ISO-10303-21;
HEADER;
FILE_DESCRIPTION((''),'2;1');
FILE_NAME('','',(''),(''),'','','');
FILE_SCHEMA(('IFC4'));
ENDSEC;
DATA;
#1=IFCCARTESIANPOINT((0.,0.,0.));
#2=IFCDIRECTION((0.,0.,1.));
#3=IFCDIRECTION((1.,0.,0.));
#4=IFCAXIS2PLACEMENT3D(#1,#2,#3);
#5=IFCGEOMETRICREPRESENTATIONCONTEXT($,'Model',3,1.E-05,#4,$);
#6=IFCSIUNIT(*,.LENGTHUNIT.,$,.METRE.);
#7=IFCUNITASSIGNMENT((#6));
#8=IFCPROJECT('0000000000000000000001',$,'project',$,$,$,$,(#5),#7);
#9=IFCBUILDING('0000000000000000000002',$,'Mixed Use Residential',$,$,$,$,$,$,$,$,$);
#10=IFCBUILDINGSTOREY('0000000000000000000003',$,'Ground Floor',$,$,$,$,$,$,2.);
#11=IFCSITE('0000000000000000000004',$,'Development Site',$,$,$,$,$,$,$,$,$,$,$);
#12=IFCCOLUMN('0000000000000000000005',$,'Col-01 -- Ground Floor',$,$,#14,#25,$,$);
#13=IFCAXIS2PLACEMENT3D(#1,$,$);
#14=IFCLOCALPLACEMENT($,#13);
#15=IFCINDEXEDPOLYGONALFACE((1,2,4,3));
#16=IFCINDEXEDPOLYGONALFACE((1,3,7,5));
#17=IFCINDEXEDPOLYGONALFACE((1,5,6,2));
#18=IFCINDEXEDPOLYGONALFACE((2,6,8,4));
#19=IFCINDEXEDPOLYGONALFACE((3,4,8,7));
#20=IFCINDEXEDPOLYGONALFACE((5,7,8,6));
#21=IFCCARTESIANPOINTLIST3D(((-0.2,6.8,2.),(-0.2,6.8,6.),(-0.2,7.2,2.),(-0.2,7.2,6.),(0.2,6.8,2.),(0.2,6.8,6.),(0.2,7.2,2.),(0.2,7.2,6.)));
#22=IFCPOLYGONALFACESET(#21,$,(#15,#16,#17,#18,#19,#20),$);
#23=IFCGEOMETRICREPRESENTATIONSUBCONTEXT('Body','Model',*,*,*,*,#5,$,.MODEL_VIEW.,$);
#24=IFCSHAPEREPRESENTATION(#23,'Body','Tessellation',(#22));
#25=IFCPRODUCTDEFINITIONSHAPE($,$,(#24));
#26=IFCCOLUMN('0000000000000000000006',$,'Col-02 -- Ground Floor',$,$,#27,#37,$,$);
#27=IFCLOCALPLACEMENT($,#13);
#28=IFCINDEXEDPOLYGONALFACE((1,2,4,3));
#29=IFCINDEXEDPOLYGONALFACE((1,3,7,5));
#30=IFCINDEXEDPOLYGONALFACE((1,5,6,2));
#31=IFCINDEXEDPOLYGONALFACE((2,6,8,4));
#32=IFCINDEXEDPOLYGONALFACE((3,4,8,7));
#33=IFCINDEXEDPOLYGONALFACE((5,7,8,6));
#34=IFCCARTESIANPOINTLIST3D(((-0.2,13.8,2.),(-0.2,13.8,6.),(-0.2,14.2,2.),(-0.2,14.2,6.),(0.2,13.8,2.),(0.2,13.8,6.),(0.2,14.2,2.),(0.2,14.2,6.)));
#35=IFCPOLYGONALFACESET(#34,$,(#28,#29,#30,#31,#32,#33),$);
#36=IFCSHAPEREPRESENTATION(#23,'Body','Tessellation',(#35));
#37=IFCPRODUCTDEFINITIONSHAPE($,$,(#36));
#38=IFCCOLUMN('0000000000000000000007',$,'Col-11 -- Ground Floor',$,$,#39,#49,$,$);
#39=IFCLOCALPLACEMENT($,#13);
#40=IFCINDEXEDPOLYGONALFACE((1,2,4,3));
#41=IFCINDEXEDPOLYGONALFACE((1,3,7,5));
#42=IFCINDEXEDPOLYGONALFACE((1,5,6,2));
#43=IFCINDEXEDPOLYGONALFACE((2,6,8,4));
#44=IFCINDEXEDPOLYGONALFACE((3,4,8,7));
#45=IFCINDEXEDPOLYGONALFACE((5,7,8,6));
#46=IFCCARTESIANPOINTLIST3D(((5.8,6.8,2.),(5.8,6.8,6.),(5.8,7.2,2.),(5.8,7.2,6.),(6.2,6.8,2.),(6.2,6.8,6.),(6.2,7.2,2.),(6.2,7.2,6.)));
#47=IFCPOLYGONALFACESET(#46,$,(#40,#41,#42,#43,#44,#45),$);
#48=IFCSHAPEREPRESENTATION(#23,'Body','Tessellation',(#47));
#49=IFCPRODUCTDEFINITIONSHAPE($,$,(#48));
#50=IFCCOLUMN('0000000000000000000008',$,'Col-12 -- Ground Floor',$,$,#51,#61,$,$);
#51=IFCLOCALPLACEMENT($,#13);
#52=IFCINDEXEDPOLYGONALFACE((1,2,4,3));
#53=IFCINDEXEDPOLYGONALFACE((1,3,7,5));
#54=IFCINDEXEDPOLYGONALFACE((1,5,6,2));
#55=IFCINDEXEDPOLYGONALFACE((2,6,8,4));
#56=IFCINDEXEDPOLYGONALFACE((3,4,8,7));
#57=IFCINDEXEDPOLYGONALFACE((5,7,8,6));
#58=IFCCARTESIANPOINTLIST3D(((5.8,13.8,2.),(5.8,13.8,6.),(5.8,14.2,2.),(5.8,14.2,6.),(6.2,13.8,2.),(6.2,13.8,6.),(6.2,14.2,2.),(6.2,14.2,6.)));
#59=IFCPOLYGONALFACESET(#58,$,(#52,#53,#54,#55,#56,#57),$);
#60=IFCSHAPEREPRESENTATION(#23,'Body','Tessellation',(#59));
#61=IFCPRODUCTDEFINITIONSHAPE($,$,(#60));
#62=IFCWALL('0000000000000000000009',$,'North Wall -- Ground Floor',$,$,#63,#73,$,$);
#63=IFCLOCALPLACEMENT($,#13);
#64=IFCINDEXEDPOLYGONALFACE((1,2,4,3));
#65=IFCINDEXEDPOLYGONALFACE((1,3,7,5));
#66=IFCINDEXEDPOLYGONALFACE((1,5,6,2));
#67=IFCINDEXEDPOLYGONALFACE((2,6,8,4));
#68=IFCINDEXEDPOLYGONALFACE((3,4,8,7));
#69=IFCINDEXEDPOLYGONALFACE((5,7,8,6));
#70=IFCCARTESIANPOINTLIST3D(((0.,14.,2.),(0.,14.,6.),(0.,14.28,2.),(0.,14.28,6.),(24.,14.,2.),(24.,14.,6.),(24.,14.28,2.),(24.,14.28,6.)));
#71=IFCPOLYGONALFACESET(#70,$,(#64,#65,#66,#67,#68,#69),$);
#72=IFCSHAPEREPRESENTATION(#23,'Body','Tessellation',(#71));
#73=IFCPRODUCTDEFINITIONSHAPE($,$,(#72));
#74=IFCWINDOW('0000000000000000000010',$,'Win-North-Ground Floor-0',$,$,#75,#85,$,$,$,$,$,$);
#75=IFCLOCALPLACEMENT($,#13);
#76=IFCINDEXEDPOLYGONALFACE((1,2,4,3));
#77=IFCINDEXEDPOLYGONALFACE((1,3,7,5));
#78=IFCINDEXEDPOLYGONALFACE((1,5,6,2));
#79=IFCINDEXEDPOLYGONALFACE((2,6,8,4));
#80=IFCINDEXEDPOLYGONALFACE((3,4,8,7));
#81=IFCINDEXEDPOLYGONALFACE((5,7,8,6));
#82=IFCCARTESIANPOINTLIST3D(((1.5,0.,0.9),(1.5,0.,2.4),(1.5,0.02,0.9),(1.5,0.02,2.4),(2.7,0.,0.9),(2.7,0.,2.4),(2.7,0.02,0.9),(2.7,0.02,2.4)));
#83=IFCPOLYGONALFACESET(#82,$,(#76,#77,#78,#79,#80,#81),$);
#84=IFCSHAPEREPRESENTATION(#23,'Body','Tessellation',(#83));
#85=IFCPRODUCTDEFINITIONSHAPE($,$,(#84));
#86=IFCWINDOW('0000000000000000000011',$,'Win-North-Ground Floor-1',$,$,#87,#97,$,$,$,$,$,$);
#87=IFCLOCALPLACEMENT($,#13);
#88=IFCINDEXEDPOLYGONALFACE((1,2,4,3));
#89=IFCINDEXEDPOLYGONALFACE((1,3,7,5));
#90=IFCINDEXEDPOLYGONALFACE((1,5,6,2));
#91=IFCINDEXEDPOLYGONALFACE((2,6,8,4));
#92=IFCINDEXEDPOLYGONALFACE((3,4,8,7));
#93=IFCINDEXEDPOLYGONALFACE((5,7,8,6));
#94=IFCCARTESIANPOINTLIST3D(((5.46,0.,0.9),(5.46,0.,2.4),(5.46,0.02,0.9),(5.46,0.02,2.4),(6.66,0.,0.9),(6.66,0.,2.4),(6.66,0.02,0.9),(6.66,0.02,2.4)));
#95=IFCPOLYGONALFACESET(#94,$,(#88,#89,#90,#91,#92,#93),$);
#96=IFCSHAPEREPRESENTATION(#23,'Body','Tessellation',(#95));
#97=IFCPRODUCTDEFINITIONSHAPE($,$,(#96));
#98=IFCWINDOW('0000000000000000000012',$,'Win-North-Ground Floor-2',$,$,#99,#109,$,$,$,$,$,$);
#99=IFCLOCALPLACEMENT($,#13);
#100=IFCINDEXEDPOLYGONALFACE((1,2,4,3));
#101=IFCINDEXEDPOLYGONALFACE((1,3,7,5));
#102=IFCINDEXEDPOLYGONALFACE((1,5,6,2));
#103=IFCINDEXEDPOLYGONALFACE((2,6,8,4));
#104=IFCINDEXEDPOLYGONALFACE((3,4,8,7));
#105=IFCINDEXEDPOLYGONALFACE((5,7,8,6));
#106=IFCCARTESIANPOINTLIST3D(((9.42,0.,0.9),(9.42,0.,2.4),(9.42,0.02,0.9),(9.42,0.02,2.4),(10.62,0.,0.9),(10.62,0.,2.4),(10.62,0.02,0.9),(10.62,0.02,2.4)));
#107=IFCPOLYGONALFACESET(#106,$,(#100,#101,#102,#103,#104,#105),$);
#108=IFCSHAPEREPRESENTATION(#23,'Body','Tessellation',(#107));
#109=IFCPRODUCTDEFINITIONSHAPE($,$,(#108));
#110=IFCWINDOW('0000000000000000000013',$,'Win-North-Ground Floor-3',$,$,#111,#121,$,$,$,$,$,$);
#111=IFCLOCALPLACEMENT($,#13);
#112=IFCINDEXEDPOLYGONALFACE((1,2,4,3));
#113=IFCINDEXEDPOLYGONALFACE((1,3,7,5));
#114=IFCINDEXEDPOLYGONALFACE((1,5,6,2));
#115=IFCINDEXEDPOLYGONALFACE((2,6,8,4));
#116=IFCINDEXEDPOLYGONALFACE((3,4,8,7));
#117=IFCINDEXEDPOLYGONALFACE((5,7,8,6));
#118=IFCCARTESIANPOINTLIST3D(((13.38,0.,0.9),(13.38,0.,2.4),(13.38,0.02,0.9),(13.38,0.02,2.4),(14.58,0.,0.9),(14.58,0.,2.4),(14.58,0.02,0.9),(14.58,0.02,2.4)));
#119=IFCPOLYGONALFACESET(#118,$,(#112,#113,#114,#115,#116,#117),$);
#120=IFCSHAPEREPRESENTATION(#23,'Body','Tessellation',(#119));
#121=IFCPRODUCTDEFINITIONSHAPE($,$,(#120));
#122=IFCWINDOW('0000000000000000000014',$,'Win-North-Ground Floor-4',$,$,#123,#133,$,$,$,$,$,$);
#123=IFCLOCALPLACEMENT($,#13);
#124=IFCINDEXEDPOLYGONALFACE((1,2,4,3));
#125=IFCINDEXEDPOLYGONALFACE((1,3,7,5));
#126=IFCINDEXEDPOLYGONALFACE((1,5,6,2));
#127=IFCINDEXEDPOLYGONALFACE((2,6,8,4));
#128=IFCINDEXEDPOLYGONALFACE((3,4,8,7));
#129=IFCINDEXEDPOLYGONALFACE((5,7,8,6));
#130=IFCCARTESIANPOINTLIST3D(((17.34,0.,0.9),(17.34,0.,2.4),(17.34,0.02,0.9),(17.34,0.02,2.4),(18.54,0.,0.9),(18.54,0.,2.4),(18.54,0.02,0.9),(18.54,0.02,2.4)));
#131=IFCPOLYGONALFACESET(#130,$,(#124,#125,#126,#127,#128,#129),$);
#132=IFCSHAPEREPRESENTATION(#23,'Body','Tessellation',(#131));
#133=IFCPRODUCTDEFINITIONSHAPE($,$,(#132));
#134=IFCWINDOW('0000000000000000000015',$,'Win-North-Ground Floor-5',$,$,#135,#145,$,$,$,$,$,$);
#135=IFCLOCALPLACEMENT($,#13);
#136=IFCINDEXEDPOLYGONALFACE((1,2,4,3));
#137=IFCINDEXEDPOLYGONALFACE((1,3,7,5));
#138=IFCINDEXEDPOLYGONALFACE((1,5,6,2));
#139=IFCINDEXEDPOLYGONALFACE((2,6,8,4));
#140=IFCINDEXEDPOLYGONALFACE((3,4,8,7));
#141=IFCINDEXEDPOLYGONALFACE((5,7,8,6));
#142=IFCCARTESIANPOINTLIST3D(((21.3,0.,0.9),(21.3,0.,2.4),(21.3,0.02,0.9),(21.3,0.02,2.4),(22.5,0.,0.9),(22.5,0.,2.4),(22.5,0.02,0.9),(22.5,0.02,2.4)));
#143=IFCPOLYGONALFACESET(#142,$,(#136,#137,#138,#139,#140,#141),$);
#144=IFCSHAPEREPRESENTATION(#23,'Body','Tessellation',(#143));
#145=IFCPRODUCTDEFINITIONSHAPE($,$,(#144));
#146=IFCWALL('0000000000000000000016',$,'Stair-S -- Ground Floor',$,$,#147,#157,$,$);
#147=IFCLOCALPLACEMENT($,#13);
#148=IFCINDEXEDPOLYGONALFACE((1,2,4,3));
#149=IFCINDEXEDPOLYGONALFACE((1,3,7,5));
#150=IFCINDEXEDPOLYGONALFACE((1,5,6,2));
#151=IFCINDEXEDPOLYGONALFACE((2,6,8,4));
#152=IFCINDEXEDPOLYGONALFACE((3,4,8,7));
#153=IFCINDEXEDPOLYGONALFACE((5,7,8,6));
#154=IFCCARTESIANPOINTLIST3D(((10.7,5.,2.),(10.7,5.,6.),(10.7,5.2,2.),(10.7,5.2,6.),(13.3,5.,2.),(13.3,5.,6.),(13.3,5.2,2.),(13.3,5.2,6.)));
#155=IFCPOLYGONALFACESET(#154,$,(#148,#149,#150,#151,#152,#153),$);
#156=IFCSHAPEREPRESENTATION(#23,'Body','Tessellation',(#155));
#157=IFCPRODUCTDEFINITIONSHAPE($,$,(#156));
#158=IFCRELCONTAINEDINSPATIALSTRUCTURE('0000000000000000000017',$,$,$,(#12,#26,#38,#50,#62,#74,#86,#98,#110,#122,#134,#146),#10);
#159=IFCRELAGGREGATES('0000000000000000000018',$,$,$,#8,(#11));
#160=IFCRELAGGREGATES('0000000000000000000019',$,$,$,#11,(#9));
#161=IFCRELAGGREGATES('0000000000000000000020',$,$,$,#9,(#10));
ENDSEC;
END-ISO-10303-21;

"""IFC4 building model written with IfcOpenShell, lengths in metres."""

from ifc_helpers import new_model, si_unit, frame, origin_with_axes, place, context, subcontext, project, spatial, indexed_curve, rectangle, outline, extrude, element, fill, save


model = new_model("IFC4")

# Units and contexts
model_context = context("Model", 3, precision=1e-05, world=origin_with_axes())
body_context = subcontext(model_context, "Body", "Model", "MODEL_VIEW")
ifc_project = project(units=[si_unit("LENGTHUNIT", "METRE")], contexts=[model_context])

# Site, building, storey
site = spatial("IfcSite", under=ifc_project, Name="Development Site")
building = spatial("IfcBuilding", under=site, Name="Mixed Use Residential")
storey = spatial("IfcBuildingStorey", under=building, Name="Ground Floor", Elevation=2.0)

# Columns
for number, where, z_axis, x_axis, name in (
    (1, (0.0, 7.0, 2.0), (0.0, 0.0, 1.0), (1.0, 0.0, 0.0), "Col-01 -- Ground Floor"),
    (2, (0.0, 14.0, 2.0), (0.0, 0.0, 1.0), (1.0, 0.0, 0.0), "Col-02 -- Ground Floor"),
    (3, (6.0, 7.0, 2.0), (0.0, 0.0, 1.0), (1.0, 0.0, 0.0), "Col-11 -- Ground Floor"),
    (4, (6.0, 14.0, 2.0), (0.0, 0.0, 1.0), (1.0, 0.0, 0.0), "Col-12 -- Ground Floor"),
):
    element("IfcColumn", number, at=place(None, frame(where, z_axis=z_axis, x_axis=x_axis)), inside=storey, Name=name, context=body_context, shape_type="SweptSolid", body=[
        extrude(rectangle(XDim=0.4, YDim=0.4), origin_with_axes(), (0.0, 0.0, 1.0), 4.0),
    ])

# Wall, openings, windows
wall_1_placement = place(None, frame((0.0, 14.0, 2.0), z_axis=(0.0, 0.0, 1.0), x_axis=(1.0, 0.0, 0.0)))
wall_1 = element("IfcWall", 5, at=wall_1_placement, inside=storey, Name="North Wall -- Ground Floor", context=body_context, shape_type="SweptSolid", body=[
    extrude(outline(indexed_curve([(0.0, 0.0), (0.0, 0.28), (24.0, 0.28), (24.0, 0.0), (0.0, 0.0)], self_intersect=False)), origin_with_axes(), (0.0, 0.0, 1.0), 4.0),
])
opening_1_placement = place(wall_1_placement, frame((1.5, -14.0, -1.1), z_axis=(0.0, 0.0, 1.0), x_axis=(1.0, 0.0, 0.0)))
opening_1 = element("IfcOpeningElement", 6, at=opening_1_placement, cuts=wall_1, context=body_context, shape_type="SweptSolid", body=[
    extrude(outline(indexed_curve([(0.0, 0.0), (0.0, 0.28), (1.2, 0.28), (1.2, 0.0), (0.0, 0.0)], self_intersect=False)), origin_with_axes(), (0.0, 0.0, 1.0), 1.5),
])
opening_2_placement = place(wall_1_placement, frame((5.46, -14.0, -1.1), z_axis=(0.0, 0.0, 1.0), x_axis=(1.0, 0.0, 0.0)))
opening_2 = element("IfcOpeningElement", 7, at=opening_2_placement, cuts=wall_1, context=body_context, shape_type="SweptSolid", body=[
    extrude(outline(indexed_curve([(0.0, 0.0), (0.0, 0.28), (1.2, 0.28), (1.2, 0.0), (0.0, 0.0)], self_intersect=False)), origin_with_axes(), (0.0, 0.0, 1.0), 1.5),
])
opening_3_placement = place(wall_1_placement, frame((9.42, -14.0, -1.1), z_axis=(0.0, 0.0, 1.0), x_axis=(1.0, 0.0, 0.0)))
opening_3 = element("IfcOpeningElement", 8, at=opening_3_placement, cuts=wall_1, context=body_context, shape_type="SweptSolid", body=[
    extrude(outline(indexed_curve([(0.0, 0.0), (0.0, 0.28), (1.2, 0.28), (1.2, 0.0), (0.0, 0.0)], self_intersect=False)), origin_with_axes(), (0.0, 0.0, 1.0), 1.5),
])
opening_4_placement = place(wall_1_placement, frame((13.38, -14.0, -1.1), z_axis=(0.0, 0.0, 1.0), x_axis=(1.0, 0.0, 0.0)))
opening_4 = element("IfcOpeningElement", 9, at=opening_4_placement, cuts=wall_1, context=body_context, shape_type="SweptSolid", body=[
    extrude(outline(indexed_curve([(0.0, 0.0), (0.0, 0.28), (1.2, 0.28), (1.2, 0.0), (0.0, 0.0)], self_intersect=False)), origin_with_axes(), (0.0, 0.0, 1.0), 1.5),
])
opening_5_placement = place(wall_1_placement, frame((17.34, -14.0, -1.1), z_axis=(0.0, 0.0, 1.0), x_axis=(1.0, 0.0, 0.0)))
opening_5 = element("IfcOpeningElement", 10, at=opening_5_placement, cuts=wall_1, context=body_context, shape_type="SweptSolid", body=[
    extrude(outline(indexed_curve([(0.0, 0.0), (0.0, 0.28), (1.2, 0.28), (1.2, 0.0), (0.0, 0.0)], self_intersect=False)), origin_with_axes(), (0.0, 0.0, 1.0), 1.5),
])
opening_6_placement = place(wall_1_placement, frame((21.3, -14.0, -1.1), z_axis=(0.0, 0.0, 1.0), x_axis=(1.0, 0.0, 0.0)))
opening_6 = element("IfcOpeningElement", 11, at=opening_6_placement, cuts=wall_1, context=body_context, shape_type="SweptSolid", body=[
    extrude(outline(indexed_curve([(0.0, 0.0), (0.0, 0.28), (1.2, 0.28), (1.2, 0.0), (0.0, 0.0)], self_intersect=False)), origin_with_axes(), (0.0, 0.0, 1.0), 1.5),
])
window_1_placement = place(None, frame((1.5, 0.0, 0.9), z_axis=(0.0, 0.0, 1.0), x_axis=(1.0, 0.0, 0.0)))
window_1 = element("IfcWindow", 12, at=window_1_placement, inside=storey, Name="Win-North-Ground Floor-0", context=body_context, shape_type="SweptSolid", body=[
    extrude(outline(indexed_curve([(0.0, 0.0), (0.0, 0.02), (1.2, 0.02), (1.2, 0.0), (0.0, 0.0)], self_intersect=False)), origin_with_axes(), (0.0, 0.0, 1.0), 1.5),
])
fill(opening_1, window_1)
window_2_placement = place(None, frame((5.46, 0.0, 0.9), z_axis=(0.0, 0.0, 1.0), x_axis=(1.0, 0.0, 0.0)))
window_2 = element("IfcWindow", 13, at=window_2_placement, inside=storey, Name="Win-North-Ground Floor-1", context=body_context, shape_type="SweptSolid", body=[
    extrude(outline(indexed_curve([(0.0, 0.0), (0.0, 0.02), (1.2, 0.02), (1.2, 0.0), (0.0, 0.0)], self_intersect=False)), origin_with_axes(), (0.0, 0.0, 1.0), 1.5),
])
fill(opening_2, window_2)
window_3_placement = place(None, frame((9.42, 0.0, 0.9), z_axis=(0.0, 0.0, 1.0), x_axis=(1.0, 0.0, 0.0)))
window_3 = element("IfcWindow", 14, at=window_3_placement, inside=storey, Name="Win-North-Ground Floor-2", context=body_context, shape_type="SweptSolid", body=[
    extrude(outline(indexed_curve([(0.0, 0.0), (0.0, 0.02), (1.2, 0.02), (1.2, 0.0), (0.0, 0.0)], self_intersect=False)), origin_with_axes(), (0.0, 0.0, 1.0), 1.5),
])
fill(opening_3, window_3)
window_4_placement = place(None, frame((13.38, 0.0, 0.9), z_axis=(0.0, 0.0, 1.0), x_axis=(1.0, 0.0, 0.0)))
window_4 = element("IfcWindow", 15, at=window_4_placement, inside=storey, Name="Win-North-Ground Floor-3", context=body_context, shape_type="SweptSolid", body=[
    extrude(outline(indexed_curve([(0.0, 0.0), (0.0, 0.02), (1.2, 0.02), (1.2, 0.0), (0.0, 0.0)], self_intersect=False)), origin_with_axes(), (0.0, 0.0, 1.0), 1.5),
])
fill(opening_4, window_4)
window_5_placement = place(None, frame((17.34, 0.0, 0.9), z_axis=(0.0, 0.0, 1.0), x_axis=(1.0, 0.0, 0.0)))
window_5 = element("IfcWindow", 16, at=window_5_placement, inside=storey, Name="Win-North-Ground Floor-4", context=body_context, shape_type="SweptSolid", body=[
    extrude(outline(indexed_curve([(0.0, 0.0), (0.0, 0.02), (1.2, 0.02), (1.2, 0.0), (0.0, 0.0)], self_intersect=False)), origin_with_axes(), (0.0, 0.0, 1.0), 1.5),
])
fill(opening_5, window_5)
window_6_placement = place(None, frame((21.3, 0.0, 0.9), z_axis=(0.0, 0.0, 1.0), x_axis=(1.0, 0.0, 0.0)))
window_6 = element("IfcWindow", 17, at=window_6_placement, inside=storey, Name="Win-North-Ground Floor-5", context=body_context, shape_type="SweptSolid", body=[
    extrude(outline(indexed_curve([(0.0, 0.0), (0.0, 0.02), (1.2, 0.02), (1.2, 0.0), (0.0, 0.0)], self_intersect=False)), origin_with_axes(), (0.0, 0.0, 1.0), 1.5),
])
fill(opening_6, window_6)

# Wall
wall_2_placement = place(None, frame((10.7, 5.0, 2.0), z_axis=(0.0, 0.0, 1.0), x_axis=(1.0, 0.0, 0.0)))
element("IfcWall", 18, at=wall_2_placement, inside=storey, Name="Stair-S -- Ground Floor", context=body_context, shape_type="SweptSolid", body=[
    extrude(outline(indexed_curve([(0.0, 0.0), (0.0, 0.2), (2.6, 0.2), (2.6, 0.0), (0.0, 0.0)], self_intersect=False)), origin_with_axes(), (0.0, 0.0, 1.0), 4.0),
])

save(model, "model.ifc")
